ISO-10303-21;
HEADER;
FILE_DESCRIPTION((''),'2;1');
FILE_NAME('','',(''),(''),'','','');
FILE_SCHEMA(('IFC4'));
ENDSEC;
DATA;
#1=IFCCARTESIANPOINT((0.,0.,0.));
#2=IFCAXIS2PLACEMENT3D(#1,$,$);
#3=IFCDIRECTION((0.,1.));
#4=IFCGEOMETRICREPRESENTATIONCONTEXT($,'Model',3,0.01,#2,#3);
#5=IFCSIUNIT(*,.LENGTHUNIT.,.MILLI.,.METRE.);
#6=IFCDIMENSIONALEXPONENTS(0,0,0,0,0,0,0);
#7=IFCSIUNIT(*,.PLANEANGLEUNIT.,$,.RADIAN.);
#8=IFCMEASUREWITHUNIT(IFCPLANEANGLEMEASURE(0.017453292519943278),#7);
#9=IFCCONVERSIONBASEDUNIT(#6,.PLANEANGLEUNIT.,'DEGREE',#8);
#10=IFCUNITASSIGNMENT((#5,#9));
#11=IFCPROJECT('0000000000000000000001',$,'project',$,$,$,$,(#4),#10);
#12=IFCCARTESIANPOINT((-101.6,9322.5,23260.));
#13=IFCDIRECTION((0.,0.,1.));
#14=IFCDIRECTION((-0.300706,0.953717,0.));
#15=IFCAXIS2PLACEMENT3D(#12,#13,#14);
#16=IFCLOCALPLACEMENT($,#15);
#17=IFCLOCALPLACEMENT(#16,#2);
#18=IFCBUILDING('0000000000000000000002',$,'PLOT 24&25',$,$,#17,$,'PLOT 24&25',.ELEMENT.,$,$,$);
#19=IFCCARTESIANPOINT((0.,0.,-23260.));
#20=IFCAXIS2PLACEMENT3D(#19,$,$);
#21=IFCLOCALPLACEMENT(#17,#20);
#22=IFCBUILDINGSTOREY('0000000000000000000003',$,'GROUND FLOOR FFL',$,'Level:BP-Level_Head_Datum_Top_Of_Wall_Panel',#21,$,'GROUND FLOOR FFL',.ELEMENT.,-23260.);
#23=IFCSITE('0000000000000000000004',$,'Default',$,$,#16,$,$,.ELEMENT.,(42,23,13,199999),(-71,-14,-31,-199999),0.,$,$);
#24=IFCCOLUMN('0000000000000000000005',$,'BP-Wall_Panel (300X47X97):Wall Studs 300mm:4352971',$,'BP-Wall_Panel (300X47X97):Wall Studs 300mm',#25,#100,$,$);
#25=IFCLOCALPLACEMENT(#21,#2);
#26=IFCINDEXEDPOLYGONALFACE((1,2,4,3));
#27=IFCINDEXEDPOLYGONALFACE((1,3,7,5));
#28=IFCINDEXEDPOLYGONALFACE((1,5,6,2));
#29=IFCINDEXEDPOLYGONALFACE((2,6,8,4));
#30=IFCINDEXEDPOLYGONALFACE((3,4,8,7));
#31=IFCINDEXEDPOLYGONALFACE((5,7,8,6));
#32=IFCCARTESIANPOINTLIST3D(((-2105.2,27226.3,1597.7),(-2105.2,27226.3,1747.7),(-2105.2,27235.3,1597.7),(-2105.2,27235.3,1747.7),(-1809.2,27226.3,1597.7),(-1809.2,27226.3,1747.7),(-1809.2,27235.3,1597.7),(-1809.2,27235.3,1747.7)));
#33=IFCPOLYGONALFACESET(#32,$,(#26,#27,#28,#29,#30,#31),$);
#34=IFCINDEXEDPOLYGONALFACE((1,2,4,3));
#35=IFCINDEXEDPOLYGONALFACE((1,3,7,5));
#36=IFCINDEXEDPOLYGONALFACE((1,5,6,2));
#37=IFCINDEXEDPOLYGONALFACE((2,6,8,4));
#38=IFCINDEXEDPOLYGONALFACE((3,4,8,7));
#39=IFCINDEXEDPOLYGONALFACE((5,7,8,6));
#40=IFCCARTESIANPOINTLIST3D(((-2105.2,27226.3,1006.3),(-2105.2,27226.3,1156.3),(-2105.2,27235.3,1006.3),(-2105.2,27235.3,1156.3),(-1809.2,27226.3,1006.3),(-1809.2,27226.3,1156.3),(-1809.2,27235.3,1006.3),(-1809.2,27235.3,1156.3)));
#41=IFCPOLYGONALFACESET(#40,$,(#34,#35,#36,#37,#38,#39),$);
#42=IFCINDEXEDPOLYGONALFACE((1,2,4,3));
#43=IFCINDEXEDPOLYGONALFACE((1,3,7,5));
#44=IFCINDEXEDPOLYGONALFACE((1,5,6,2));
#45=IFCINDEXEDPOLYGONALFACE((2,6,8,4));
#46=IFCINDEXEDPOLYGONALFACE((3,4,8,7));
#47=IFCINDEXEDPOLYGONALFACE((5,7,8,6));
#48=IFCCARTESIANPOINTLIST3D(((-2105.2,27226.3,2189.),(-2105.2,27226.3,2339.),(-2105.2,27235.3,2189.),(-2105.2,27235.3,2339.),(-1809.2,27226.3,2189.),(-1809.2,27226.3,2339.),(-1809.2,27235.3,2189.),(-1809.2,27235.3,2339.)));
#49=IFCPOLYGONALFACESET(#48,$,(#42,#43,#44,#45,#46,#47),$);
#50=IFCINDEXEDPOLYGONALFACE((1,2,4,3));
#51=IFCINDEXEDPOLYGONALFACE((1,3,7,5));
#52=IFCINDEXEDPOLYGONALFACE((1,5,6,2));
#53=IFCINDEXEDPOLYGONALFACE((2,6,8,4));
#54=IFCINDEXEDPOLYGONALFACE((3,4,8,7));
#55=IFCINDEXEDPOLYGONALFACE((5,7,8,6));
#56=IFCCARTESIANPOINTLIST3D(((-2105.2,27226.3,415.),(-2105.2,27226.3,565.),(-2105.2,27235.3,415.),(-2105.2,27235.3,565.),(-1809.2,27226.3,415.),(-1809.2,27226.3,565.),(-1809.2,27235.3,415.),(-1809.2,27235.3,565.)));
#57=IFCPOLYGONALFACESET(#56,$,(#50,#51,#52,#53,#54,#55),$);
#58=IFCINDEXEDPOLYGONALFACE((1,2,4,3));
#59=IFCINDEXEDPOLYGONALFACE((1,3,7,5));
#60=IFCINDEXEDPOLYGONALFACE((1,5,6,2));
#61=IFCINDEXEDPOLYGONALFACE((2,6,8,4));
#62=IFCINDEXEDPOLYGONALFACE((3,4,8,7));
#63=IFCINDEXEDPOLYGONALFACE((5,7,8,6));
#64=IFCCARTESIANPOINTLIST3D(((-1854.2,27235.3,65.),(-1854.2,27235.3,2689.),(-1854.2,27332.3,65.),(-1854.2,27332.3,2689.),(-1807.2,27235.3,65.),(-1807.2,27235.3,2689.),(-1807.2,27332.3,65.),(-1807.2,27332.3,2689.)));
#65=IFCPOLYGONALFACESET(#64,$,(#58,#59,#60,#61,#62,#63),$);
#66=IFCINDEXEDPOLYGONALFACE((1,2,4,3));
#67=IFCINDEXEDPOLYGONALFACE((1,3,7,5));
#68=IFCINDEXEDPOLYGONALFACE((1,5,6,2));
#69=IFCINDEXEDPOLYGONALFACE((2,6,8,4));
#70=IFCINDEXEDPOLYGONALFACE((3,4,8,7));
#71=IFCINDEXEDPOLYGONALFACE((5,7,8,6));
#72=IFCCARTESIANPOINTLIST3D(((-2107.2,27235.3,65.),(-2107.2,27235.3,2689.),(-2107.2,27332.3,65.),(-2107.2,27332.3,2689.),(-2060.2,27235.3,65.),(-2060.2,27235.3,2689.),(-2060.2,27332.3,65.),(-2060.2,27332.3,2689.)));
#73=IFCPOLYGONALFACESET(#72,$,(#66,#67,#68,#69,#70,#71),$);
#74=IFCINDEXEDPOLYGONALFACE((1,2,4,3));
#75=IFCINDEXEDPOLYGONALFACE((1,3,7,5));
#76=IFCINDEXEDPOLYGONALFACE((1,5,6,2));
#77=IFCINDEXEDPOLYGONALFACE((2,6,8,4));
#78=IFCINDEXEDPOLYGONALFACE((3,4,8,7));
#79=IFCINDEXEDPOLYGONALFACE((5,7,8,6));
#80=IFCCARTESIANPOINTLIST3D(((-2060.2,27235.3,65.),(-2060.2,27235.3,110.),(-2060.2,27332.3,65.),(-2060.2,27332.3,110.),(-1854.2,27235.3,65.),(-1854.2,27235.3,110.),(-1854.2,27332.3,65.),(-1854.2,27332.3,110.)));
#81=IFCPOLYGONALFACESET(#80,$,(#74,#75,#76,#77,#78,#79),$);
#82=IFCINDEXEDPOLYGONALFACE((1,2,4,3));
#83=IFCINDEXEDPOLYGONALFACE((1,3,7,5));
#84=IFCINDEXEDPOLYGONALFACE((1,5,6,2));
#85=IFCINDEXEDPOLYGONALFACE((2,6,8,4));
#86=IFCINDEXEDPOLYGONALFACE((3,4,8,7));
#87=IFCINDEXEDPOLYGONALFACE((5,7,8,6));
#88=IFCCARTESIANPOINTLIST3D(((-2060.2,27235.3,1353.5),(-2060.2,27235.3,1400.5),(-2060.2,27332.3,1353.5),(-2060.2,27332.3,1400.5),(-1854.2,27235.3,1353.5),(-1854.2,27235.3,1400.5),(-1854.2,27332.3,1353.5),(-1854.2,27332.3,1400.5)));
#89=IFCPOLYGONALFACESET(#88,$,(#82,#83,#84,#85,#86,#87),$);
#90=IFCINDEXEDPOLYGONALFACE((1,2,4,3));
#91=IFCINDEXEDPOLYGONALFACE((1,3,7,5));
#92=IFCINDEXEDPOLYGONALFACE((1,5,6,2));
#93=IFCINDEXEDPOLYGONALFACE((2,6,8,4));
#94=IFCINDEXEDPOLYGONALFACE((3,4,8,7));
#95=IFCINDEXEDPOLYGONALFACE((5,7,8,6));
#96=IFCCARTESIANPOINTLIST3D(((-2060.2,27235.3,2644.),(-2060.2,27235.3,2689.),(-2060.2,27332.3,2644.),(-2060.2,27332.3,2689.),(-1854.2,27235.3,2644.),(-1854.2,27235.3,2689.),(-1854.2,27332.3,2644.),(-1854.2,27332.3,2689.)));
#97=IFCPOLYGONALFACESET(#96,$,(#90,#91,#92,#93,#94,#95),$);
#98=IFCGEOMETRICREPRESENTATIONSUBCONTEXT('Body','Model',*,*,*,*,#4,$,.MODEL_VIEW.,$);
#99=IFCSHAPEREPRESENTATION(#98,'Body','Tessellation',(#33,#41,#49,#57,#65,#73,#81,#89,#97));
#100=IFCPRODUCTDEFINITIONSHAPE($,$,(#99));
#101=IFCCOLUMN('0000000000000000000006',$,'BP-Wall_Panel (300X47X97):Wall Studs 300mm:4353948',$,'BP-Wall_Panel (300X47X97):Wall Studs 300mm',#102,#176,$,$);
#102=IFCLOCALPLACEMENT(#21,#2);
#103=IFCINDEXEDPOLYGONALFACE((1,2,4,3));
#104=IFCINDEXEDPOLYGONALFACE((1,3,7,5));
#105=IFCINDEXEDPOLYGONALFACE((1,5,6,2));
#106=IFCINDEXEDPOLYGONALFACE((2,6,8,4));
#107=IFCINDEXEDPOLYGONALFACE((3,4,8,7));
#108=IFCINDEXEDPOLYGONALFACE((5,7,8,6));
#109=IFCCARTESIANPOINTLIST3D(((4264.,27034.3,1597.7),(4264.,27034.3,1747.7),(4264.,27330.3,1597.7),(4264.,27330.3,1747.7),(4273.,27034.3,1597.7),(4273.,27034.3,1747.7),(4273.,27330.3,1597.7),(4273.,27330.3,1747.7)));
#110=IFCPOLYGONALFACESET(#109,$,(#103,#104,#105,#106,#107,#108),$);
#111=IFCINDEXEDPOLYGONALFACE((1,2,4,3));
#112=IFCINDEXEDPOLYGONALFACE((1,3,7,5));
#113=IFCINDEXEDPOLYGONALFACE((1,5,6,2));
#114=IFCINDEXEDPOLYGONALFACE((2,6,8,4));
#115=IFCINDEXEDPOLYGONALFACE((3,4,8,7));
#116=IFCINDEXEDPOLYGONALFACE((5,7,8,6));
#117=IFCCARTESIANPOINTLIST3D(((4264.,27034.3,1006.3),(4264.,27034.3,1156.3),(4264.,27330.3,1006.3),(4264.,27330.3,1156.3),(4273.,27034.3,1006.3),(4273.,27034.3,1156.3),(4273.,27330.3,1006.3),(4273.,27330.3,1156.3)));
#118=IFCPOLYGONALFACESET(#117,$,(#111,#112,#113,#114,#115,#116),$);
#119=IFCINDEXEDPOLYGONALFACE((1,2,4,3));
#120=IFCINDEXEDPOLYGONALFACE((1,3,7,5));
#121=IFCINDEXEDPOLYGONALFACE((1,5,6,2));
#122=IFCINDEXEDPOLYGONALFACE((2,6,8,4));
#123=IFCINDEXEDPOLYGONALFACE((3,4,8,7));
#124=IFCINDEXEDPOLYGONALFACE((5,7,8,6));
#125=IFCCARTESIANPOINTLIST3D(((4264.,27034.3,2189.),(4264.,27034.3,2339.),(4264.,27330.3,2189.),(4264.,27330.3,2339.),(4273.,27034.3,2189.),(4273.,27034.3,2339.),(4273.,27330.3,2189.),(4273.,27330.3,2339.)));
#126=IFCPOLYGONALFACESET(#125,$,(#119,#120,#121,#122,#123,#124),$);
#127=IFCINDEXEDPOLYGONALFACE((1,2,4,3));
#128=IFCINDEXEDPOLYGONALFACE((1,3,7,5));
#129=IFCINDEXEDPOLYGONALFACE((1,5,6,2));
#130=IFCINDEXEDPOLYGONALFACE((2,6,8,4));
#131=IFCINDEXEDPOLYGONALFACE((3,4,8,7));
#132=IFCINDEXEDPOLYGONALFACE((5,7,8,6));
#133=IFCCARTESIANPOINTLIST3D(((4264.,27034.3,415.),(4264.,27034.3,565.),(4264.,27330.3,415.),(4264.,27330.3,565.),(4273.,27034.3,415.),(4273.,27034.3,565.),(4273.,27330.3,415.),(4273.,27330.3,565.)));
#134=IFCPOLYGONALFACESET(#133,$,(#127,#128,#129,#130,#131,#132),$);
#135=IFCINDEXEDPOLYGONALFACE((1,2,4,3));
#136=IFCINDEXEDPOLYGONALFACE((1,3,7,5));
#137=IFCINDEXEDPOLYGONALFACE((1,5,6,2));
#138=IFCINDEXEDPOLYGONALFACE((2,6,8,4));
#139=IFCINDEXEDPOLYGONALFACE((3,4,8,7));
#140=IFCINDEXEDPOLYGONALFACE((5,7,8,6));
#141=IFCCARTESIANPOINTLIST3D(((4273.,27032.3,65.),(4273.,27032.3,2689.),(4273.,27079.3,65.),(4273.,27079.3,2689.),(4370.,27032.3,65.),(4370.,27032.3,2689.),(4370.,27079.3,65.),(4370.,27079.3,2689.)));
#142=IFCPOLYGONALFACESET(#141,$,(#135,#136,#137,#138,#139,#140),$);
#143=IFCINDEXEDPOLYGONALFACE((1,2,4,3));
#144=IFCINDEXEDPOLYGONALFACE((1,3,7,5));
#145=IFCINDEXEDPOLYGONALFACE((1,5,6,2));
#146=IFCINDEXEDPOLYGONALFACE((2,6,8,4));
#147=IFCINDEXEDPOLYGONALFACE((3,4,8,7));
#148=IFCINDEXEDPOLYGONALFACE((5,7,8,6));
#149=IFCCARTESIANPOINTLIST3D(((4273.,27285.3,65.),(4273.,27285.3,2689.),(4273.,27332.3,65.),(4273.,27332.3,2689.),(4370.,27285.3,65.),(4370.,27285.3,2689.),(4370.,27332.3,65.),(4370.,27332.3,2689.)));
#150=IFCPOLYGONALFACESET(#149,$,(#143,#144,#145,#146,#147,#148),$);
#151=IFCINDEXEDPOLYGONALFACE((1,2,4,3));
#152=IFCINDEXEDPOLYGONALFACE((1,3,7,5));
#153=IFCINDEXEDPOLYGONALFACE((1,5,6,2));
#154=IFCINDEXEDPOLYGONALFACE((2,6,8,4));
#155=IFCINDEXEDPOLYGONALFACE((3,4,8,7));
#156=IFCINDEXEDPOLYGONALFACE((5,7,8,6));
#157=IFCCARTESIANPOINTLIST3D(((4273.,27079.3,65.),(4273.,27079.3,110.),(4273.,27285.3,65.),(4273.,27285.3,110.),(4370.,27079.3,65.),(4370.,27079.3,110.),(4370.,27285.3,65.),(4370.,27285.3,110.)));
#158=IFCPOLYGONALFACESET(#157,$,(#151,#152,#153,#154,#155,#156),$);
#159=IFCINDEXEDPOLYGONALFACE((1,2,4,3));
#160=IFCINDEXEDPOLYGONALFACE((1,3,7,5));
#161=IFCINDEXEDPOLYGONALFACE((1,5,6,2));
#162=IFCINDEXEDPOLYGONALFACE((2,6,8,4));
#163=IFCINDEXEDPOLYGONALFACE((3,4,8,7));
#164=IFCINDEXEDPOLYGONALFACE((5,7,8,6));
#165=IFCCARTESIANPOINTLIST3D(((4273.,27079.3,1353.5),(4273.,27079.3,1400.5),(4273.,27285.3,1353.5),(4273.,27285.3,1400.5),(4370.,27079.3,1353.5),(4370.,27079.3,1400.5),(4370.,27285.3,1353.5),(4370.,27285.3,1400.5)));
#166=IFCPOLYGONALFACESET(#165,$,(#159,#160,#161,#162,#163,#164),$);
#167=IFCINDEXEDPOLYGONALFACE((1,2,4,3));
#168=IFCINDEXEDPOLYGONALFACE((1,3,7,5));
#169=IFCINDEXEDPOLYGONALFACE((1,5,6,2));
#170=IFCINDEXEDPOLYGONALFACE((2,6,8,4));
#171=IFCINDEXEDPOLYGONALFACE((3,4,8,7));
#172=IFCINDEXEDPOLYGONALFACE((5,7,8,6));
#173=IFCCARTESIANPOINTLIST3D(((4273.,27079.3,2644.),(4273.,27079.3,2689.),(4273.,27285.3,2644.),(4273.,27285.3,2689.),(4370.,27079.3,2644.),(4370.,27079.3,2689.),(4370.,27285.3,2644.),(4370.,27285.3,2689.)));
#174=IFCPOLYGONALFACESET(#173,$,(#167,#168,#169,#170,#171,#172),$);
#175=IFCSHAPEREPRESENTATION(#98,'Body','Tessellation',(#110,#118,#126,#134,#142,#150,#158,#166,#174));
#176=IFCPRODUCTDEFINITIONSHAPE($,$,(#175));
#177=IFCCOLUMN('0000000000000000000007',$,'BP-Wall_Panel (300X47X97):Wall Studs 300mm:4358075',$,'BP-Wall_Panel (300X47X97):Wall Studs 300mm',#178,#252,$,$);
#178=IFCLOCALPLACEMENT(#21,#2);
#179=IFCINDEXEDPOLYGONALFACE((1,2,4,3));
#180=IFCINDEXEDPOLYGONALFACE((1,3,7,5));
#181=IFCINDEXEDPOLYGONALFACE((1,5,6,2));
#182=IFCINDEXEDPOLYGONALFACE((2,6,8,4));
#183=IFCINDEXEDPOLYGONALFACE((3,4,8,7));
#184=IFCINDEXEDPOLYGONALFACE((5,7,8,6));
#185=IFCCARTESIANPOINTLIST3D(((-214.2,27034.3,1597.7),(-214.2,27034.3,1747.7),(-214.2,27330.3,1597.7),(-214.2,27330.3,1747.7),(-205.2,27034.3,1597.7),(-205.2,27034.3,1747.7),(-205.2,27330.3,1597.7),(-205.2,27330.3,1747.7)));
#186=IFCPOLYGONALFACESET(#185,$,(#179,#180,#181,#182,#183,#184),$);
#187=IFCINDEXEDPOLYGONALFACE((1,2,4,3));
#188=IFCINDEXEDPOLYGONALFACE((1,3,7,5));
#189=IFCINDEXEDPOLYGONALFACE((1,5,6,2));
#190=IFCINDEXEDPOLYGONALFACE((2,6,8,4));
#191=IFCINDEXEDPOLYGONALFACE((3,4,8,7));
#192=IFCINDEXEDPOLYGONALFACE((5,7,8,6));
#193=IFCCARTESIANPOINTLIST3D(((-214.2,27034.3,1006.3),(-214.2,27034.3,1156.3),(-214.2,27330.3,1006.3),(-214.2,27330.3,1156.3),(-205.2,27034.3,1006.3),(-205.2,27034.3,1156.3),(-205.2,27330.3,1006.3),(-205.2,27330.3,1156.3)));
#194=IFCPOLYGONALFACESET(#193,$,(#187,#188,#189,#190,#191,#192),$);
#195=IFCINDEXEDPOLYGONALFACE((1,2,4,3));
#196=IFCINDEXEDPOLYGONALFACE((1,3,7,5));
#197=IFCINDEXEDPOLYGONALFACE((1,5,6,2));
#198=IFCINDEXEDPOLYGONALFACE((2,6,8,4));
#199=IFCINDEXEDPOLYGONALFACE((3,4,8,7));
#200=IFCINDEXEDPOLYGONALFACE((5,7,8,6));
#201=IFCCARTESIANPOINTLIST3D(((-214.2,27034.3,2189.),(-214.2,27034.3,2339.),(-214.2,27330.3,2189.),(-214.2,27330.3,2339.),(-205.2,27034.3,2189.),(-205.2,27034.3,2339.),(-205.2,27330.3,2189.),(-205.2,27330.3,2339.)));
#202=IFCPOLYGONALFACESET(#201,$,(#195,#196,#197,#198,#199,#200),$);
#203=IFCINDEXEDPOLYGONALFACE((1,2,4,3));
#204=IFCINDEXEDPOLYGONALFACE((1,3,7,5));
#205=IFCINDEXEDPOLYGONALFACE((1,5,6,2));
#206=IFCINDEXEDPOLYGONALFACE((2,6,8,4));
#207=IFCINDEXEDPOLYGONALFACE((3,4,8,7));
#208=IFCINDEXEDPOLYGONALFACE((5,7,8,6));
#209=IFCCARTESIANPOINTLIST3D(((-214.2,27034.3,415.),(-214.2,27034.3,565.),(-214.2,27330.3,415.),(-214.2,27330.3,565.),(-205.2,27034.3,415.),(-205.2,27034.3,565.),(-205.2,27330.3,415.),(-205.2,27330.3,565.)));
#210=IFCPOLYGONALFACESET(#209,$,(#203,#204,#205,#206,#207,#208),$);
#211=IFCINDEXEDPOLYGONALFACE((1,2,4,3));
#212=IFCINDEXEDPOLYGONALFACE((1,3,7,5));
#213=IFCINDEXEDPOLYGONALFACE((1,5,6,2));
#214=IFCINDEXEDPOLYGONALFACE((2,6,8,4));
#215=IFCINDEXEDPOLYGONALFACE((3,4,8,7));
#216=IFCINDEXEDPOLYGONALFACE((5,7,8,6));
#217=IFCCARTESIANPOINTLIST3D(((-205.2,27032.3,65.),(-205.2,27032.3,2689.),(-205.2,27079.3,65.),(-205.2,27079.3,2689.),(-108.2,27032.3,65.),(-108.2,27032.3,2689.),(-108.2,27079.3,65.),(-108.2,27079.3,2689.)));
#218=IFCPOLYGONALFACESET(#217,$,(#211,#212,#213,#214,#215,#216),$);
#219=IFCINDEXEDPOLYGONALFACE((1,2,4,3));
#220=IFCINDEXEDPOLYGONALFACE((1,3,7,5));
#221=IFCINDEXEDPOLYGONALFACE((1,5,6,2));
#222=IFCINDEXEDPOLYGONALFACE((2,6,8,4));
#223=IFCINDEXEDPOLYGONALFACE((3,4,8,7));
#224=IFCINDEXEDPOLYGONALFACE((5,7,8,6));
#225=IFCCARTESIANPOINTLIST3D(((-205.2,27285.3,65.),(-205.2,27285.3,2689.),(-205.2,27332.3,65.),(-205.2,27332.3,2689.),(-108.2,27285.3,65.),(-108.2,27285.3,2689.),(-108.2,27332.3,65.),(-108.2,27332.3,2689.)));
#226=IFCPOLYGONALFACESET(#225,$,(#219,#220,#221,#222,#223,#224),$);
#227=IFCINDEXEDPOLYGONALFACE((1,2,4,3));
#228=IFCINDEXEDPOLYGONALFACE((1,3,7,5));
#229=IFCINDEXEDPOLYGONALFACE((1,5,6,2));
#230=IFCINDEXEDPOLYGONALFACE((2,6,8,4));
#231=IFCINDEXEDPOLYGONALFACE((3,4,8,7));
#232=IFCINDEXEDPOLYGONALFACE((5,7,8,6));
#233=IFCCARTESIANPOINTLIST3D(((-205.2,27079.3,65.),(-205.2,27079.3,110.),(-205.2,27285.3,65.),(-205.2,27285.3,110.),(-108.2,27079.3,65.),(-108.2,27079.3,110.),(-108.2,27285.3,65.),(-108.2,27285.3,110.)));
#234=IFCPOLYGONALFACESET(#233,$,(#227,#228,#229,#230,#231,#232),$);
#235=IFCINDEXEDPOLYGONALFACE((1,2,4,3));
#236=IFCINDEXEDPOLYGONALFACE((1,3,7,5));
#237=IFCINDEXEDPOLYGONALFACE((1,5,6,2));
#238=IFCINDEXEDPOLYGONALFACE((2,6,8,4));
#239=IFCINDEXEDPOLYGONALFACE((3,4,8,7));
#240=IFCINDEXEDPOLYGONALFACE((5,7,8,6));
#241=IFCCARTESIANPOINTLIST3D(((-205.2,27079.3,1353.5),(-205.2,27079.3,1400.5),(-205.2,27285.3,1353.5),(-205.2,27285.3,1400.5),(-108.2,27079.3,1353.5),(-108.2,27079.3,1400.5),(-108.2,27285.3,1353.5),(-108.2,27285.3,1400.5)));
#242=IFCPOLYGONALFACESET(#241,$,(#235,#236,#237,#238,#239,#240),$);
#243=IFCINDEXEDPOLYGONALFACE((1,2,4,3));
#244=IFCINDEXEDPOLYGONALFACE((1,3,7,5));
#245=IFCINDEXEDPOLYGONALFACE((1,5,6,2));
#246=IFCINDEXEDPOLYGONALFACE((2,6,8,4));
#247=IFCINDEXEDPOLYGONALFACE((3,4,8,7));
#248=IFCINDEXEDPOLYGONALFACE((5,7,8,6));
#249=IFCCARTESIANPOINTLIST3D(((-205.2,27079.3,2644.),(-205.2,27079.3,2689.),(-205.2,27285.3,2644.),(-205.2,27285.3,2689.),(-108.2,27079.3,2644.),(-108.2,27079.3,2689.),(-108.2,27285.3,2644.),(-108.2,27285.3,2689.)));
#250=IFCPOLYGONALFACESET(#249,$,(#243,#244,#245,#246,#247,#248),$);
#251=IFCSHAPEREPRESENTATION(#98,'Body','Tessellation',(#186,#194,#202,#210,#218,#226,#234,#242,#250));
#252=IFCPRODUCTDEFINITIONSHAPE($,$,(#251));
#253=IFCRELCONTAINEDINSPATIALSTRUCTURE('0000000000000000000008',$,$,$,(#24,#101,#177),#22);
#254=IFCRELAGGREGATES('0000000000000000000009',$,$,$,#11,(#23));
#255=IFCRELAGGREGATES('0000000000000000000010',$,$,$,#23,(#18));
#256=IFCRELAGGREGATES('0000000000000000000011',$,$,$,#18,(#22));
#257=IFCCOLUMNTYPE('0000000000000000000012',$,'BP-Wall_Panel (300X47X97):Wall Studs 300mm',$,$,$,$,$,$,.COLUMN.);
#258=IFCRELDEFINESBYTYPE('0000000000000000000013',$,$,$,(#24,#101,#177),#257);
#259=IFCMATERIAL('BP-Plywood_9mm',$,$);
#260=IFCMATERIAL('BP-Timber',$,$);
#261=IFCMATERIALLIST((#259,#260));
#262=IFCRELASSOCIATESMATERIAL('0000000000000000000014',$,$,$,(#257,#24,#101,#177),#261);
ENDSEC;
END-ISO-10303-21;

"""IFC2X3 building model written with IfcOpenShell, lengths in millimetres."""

from ifc_helpers import new_model, entity, si_unit, converted_unit, direction, frame, frame_2d, origin, origin_2d_with_axis, place, context, subcontext, project, spatial, rectangle, extrude, source, transform, mapped, material, material_list, type_object, type_shapes, element, save


model = new_model("IFC2X3")

# Units and contexts
model_context = context("Model", 3, precision=0.01, world=origin(), true_north=direction((0.0, 1.0)))
body_context = subcontext(model_context, "Body", "Model", "MODEL_VIEW")
ifc_project = project(units=[si_unit("LENGTHUNIT", "METRE", prefix="MILLI"), converted_unit("PLANEANGLEUNIT", "DEGREE", entity("IfcPlaneAngleMeasure", 0.017453292519943278), si_unit("PLANEANGLEUNIT", "RADIAN"), dimensions=[0, 0, 0, 0, 0, 0, 0])], contexts=[model_context])

# Site, building, storey
site_placement = place(None, frame((-101.6, 9322.5, 23260.0), z_axis=(0.0, 0.0, 1.0), x_axis=(-0.300706, 0.953717, 0.0)))
site = spatial("IfcSite", under=ifc_project, at=site_placement, Name="Default", CompositionType="ELEMENT", RefLatitude=(42, 23, 13, 199999), RefLongitude=(-71, -14, -31, -199999), RefElevation=0.0)
building_placement = place(site_placement, origin())
building = spatial("IfcBuilding", under=site, at=building_placement, Name="PLOT 24&25", LongName="PLOT 24&25", CompositionType="ELEMENT")
storey_placement = place(building_placement, frame((0.0, 0.0, -23260.0)))
storey = spatial("IfcBuildingStorey", under=building, at=storey_placement, Name="GROUND FLOOR FFL", ObjectType="Level:BP-Level_Head_Datum_Top_Of_Wall_Panel", LongName="GROUND FLOOR FFL", CompositionType="ELEMENT", Elevation=-23260.0)

# Columns
ifc_material_1 = material(Name="BP-Plywood_9mm")
ifc_material_2 = material(Name="BP-Timber")
ifc_material_list = material_list([ifc_material_1, ifc_material_2])
column_type_1 = type_object("IfcColumnType", Name="BP-Wall_Panel (300X47X97):Wall Studs 300mm", PredefinedType="COLUMN", material=ifc_material_list)
shared_shape_1 = source(origin(), body_context, "Body", "SweptSolid", [
    extrude(rectangle(XDim=9.0, YDim=296.0, at=origin_2d_with_axis()), frame((-53.0, 0.0, -21662.3), z_axis=(0.0, 0.0, 1.0), x_axis=(-1.0, 0.0, 0.0)), (0.0, 0.0, 1.0), 150.0),
    extrude(rectangle(XDim=9.0, YDim=296.0, at=origin_2d_with_axis()), frame((-53.0, 0.0, -22253.7), z_axis=(0.0, 0.0, 1.0), x_axis=(-1.0, 0.0, 0.0)), (0.0, 0.0, 1.0), 150.0),
    extrude(rectangle(XDim=9.0, YDim=296.0, at=origin_2d_with_axis()), frame((-53.0, 0.0, -21071.0), z_axis=(0.0, 0.0, 1.0), x_axis=(-1.0, 0.0, 0.0)), (0.0, 0.0, 1.0), 150.0),
    extrude(rectangle(XDim=9.0, YDim=296.0, at=origin_2d_with_axis()), frame((-53.0, 0.0, -22845.0), z_axis=(0.0, 0.0, 1.0), x_axis=(-1.0, 0.0, 0.0)), (0.0, 0.0, 1.0), 150.0),
    extrude(rectangle(XDim=97.0, YDim=47.0, at=origin_2d_with_axis()), frame((0.0, -126.5, -23195.0), z_axis=(0.0, 0.0, 1.0), x_axis=(-1.0, 0.0, 0.0)), (0.0, 0.0, 1.0), 2624.0),
    extrude(rectangle(XDim=97.0, YDim=47.0, at=frame_2d((0.0, 0.0), x_axis=(1.0, 0.0))), frame((0.0, 126.5, -23195.0), z_axis=(0.0, 0.0, 1.0), x_axis=(-1.0, 0.0, 0.0)), (0.0, 0.0, 1.0), 2624.0),
    extrude(rectangle(XDim=206.0, YDim=97.0, at=origin_2d_with_axis()), frame((0.0, 0.0, -23195.0), z_axis=(0.0, 0.0, 1.0), x_axis=(0.0, -1.0, 0.0)), (0.0, 0.0, 1.0), 45.0),
    extrude(rectangle(XDim=206.0, YDim=97.0, at=origin_2d_with_axis()), frame((0.0, 0.0, -21906.5), z_axis=(0.0, 0.0, 1.0), x_axis=(0.0, -1.0, 0.0)), (0.0, 0.0, 1.0), 47.0),
    extrude(rectangle(XDim=206.0, YDim=97.0, at=origin_2d_with_axis()), frame((0.0, 0.0, -20616.0), z_axis=(0.0, 0.0, 1.0), x_axis=(0.0, -1.0, 0.0)), (0.0, 0.0, 1.0), 45.0),
])
type_shapes(column_type_1, [shared_shape_1])
column_placement = place(storey_placement, frame((-1957.2, 27283.8, 23260.0), z_axis=(0.0, 0.0, 1.0), x_axis=(0.0, 1.0, 0.0)))
element("IfcColumn", 1, at=column_placement, inside=storey, type_object=column_type_1, material=ifc_material_list, Name="BP-Wall_Panel (300X47X97):Wall Studs 300mm:4352971", ObjectType="BP-Wall_Panel (300X47X97):Wall Studs 300mm", context=body_context, shape_type="MappedRepresentation", body=[
    mapped(shared_shape_1, transform((0.0, 0.0, 0.0), scale=1.0)),
])
for number, where, name in (
    (2, (4321.5, 27182.3, 23260.0), "BP-Wall_Panel (300X47X97):Wall Studs 300mm:4353948"),
    (3, (-156.7, 27182.3, 23260.0), "BP-Wall_Panel (300X47X97):Wall Studs 300mm:4358075"),
):
    element("IfcColumn", number, at=place(storey_placement, frame(where)), inside=storey, type_object=column_type_1, material=ifc_material_list, Name=name, ObjectType="BP-Wall_Panel (300X47X97):Wall Studs 300mm", context=body_context, shape_type="MappedRepresentation", body=[
        mapped(shared_shape_1, transform((0.0, 0.0, 0.0), scale=1.0)),
    ])

save(model, "model.ifc")
